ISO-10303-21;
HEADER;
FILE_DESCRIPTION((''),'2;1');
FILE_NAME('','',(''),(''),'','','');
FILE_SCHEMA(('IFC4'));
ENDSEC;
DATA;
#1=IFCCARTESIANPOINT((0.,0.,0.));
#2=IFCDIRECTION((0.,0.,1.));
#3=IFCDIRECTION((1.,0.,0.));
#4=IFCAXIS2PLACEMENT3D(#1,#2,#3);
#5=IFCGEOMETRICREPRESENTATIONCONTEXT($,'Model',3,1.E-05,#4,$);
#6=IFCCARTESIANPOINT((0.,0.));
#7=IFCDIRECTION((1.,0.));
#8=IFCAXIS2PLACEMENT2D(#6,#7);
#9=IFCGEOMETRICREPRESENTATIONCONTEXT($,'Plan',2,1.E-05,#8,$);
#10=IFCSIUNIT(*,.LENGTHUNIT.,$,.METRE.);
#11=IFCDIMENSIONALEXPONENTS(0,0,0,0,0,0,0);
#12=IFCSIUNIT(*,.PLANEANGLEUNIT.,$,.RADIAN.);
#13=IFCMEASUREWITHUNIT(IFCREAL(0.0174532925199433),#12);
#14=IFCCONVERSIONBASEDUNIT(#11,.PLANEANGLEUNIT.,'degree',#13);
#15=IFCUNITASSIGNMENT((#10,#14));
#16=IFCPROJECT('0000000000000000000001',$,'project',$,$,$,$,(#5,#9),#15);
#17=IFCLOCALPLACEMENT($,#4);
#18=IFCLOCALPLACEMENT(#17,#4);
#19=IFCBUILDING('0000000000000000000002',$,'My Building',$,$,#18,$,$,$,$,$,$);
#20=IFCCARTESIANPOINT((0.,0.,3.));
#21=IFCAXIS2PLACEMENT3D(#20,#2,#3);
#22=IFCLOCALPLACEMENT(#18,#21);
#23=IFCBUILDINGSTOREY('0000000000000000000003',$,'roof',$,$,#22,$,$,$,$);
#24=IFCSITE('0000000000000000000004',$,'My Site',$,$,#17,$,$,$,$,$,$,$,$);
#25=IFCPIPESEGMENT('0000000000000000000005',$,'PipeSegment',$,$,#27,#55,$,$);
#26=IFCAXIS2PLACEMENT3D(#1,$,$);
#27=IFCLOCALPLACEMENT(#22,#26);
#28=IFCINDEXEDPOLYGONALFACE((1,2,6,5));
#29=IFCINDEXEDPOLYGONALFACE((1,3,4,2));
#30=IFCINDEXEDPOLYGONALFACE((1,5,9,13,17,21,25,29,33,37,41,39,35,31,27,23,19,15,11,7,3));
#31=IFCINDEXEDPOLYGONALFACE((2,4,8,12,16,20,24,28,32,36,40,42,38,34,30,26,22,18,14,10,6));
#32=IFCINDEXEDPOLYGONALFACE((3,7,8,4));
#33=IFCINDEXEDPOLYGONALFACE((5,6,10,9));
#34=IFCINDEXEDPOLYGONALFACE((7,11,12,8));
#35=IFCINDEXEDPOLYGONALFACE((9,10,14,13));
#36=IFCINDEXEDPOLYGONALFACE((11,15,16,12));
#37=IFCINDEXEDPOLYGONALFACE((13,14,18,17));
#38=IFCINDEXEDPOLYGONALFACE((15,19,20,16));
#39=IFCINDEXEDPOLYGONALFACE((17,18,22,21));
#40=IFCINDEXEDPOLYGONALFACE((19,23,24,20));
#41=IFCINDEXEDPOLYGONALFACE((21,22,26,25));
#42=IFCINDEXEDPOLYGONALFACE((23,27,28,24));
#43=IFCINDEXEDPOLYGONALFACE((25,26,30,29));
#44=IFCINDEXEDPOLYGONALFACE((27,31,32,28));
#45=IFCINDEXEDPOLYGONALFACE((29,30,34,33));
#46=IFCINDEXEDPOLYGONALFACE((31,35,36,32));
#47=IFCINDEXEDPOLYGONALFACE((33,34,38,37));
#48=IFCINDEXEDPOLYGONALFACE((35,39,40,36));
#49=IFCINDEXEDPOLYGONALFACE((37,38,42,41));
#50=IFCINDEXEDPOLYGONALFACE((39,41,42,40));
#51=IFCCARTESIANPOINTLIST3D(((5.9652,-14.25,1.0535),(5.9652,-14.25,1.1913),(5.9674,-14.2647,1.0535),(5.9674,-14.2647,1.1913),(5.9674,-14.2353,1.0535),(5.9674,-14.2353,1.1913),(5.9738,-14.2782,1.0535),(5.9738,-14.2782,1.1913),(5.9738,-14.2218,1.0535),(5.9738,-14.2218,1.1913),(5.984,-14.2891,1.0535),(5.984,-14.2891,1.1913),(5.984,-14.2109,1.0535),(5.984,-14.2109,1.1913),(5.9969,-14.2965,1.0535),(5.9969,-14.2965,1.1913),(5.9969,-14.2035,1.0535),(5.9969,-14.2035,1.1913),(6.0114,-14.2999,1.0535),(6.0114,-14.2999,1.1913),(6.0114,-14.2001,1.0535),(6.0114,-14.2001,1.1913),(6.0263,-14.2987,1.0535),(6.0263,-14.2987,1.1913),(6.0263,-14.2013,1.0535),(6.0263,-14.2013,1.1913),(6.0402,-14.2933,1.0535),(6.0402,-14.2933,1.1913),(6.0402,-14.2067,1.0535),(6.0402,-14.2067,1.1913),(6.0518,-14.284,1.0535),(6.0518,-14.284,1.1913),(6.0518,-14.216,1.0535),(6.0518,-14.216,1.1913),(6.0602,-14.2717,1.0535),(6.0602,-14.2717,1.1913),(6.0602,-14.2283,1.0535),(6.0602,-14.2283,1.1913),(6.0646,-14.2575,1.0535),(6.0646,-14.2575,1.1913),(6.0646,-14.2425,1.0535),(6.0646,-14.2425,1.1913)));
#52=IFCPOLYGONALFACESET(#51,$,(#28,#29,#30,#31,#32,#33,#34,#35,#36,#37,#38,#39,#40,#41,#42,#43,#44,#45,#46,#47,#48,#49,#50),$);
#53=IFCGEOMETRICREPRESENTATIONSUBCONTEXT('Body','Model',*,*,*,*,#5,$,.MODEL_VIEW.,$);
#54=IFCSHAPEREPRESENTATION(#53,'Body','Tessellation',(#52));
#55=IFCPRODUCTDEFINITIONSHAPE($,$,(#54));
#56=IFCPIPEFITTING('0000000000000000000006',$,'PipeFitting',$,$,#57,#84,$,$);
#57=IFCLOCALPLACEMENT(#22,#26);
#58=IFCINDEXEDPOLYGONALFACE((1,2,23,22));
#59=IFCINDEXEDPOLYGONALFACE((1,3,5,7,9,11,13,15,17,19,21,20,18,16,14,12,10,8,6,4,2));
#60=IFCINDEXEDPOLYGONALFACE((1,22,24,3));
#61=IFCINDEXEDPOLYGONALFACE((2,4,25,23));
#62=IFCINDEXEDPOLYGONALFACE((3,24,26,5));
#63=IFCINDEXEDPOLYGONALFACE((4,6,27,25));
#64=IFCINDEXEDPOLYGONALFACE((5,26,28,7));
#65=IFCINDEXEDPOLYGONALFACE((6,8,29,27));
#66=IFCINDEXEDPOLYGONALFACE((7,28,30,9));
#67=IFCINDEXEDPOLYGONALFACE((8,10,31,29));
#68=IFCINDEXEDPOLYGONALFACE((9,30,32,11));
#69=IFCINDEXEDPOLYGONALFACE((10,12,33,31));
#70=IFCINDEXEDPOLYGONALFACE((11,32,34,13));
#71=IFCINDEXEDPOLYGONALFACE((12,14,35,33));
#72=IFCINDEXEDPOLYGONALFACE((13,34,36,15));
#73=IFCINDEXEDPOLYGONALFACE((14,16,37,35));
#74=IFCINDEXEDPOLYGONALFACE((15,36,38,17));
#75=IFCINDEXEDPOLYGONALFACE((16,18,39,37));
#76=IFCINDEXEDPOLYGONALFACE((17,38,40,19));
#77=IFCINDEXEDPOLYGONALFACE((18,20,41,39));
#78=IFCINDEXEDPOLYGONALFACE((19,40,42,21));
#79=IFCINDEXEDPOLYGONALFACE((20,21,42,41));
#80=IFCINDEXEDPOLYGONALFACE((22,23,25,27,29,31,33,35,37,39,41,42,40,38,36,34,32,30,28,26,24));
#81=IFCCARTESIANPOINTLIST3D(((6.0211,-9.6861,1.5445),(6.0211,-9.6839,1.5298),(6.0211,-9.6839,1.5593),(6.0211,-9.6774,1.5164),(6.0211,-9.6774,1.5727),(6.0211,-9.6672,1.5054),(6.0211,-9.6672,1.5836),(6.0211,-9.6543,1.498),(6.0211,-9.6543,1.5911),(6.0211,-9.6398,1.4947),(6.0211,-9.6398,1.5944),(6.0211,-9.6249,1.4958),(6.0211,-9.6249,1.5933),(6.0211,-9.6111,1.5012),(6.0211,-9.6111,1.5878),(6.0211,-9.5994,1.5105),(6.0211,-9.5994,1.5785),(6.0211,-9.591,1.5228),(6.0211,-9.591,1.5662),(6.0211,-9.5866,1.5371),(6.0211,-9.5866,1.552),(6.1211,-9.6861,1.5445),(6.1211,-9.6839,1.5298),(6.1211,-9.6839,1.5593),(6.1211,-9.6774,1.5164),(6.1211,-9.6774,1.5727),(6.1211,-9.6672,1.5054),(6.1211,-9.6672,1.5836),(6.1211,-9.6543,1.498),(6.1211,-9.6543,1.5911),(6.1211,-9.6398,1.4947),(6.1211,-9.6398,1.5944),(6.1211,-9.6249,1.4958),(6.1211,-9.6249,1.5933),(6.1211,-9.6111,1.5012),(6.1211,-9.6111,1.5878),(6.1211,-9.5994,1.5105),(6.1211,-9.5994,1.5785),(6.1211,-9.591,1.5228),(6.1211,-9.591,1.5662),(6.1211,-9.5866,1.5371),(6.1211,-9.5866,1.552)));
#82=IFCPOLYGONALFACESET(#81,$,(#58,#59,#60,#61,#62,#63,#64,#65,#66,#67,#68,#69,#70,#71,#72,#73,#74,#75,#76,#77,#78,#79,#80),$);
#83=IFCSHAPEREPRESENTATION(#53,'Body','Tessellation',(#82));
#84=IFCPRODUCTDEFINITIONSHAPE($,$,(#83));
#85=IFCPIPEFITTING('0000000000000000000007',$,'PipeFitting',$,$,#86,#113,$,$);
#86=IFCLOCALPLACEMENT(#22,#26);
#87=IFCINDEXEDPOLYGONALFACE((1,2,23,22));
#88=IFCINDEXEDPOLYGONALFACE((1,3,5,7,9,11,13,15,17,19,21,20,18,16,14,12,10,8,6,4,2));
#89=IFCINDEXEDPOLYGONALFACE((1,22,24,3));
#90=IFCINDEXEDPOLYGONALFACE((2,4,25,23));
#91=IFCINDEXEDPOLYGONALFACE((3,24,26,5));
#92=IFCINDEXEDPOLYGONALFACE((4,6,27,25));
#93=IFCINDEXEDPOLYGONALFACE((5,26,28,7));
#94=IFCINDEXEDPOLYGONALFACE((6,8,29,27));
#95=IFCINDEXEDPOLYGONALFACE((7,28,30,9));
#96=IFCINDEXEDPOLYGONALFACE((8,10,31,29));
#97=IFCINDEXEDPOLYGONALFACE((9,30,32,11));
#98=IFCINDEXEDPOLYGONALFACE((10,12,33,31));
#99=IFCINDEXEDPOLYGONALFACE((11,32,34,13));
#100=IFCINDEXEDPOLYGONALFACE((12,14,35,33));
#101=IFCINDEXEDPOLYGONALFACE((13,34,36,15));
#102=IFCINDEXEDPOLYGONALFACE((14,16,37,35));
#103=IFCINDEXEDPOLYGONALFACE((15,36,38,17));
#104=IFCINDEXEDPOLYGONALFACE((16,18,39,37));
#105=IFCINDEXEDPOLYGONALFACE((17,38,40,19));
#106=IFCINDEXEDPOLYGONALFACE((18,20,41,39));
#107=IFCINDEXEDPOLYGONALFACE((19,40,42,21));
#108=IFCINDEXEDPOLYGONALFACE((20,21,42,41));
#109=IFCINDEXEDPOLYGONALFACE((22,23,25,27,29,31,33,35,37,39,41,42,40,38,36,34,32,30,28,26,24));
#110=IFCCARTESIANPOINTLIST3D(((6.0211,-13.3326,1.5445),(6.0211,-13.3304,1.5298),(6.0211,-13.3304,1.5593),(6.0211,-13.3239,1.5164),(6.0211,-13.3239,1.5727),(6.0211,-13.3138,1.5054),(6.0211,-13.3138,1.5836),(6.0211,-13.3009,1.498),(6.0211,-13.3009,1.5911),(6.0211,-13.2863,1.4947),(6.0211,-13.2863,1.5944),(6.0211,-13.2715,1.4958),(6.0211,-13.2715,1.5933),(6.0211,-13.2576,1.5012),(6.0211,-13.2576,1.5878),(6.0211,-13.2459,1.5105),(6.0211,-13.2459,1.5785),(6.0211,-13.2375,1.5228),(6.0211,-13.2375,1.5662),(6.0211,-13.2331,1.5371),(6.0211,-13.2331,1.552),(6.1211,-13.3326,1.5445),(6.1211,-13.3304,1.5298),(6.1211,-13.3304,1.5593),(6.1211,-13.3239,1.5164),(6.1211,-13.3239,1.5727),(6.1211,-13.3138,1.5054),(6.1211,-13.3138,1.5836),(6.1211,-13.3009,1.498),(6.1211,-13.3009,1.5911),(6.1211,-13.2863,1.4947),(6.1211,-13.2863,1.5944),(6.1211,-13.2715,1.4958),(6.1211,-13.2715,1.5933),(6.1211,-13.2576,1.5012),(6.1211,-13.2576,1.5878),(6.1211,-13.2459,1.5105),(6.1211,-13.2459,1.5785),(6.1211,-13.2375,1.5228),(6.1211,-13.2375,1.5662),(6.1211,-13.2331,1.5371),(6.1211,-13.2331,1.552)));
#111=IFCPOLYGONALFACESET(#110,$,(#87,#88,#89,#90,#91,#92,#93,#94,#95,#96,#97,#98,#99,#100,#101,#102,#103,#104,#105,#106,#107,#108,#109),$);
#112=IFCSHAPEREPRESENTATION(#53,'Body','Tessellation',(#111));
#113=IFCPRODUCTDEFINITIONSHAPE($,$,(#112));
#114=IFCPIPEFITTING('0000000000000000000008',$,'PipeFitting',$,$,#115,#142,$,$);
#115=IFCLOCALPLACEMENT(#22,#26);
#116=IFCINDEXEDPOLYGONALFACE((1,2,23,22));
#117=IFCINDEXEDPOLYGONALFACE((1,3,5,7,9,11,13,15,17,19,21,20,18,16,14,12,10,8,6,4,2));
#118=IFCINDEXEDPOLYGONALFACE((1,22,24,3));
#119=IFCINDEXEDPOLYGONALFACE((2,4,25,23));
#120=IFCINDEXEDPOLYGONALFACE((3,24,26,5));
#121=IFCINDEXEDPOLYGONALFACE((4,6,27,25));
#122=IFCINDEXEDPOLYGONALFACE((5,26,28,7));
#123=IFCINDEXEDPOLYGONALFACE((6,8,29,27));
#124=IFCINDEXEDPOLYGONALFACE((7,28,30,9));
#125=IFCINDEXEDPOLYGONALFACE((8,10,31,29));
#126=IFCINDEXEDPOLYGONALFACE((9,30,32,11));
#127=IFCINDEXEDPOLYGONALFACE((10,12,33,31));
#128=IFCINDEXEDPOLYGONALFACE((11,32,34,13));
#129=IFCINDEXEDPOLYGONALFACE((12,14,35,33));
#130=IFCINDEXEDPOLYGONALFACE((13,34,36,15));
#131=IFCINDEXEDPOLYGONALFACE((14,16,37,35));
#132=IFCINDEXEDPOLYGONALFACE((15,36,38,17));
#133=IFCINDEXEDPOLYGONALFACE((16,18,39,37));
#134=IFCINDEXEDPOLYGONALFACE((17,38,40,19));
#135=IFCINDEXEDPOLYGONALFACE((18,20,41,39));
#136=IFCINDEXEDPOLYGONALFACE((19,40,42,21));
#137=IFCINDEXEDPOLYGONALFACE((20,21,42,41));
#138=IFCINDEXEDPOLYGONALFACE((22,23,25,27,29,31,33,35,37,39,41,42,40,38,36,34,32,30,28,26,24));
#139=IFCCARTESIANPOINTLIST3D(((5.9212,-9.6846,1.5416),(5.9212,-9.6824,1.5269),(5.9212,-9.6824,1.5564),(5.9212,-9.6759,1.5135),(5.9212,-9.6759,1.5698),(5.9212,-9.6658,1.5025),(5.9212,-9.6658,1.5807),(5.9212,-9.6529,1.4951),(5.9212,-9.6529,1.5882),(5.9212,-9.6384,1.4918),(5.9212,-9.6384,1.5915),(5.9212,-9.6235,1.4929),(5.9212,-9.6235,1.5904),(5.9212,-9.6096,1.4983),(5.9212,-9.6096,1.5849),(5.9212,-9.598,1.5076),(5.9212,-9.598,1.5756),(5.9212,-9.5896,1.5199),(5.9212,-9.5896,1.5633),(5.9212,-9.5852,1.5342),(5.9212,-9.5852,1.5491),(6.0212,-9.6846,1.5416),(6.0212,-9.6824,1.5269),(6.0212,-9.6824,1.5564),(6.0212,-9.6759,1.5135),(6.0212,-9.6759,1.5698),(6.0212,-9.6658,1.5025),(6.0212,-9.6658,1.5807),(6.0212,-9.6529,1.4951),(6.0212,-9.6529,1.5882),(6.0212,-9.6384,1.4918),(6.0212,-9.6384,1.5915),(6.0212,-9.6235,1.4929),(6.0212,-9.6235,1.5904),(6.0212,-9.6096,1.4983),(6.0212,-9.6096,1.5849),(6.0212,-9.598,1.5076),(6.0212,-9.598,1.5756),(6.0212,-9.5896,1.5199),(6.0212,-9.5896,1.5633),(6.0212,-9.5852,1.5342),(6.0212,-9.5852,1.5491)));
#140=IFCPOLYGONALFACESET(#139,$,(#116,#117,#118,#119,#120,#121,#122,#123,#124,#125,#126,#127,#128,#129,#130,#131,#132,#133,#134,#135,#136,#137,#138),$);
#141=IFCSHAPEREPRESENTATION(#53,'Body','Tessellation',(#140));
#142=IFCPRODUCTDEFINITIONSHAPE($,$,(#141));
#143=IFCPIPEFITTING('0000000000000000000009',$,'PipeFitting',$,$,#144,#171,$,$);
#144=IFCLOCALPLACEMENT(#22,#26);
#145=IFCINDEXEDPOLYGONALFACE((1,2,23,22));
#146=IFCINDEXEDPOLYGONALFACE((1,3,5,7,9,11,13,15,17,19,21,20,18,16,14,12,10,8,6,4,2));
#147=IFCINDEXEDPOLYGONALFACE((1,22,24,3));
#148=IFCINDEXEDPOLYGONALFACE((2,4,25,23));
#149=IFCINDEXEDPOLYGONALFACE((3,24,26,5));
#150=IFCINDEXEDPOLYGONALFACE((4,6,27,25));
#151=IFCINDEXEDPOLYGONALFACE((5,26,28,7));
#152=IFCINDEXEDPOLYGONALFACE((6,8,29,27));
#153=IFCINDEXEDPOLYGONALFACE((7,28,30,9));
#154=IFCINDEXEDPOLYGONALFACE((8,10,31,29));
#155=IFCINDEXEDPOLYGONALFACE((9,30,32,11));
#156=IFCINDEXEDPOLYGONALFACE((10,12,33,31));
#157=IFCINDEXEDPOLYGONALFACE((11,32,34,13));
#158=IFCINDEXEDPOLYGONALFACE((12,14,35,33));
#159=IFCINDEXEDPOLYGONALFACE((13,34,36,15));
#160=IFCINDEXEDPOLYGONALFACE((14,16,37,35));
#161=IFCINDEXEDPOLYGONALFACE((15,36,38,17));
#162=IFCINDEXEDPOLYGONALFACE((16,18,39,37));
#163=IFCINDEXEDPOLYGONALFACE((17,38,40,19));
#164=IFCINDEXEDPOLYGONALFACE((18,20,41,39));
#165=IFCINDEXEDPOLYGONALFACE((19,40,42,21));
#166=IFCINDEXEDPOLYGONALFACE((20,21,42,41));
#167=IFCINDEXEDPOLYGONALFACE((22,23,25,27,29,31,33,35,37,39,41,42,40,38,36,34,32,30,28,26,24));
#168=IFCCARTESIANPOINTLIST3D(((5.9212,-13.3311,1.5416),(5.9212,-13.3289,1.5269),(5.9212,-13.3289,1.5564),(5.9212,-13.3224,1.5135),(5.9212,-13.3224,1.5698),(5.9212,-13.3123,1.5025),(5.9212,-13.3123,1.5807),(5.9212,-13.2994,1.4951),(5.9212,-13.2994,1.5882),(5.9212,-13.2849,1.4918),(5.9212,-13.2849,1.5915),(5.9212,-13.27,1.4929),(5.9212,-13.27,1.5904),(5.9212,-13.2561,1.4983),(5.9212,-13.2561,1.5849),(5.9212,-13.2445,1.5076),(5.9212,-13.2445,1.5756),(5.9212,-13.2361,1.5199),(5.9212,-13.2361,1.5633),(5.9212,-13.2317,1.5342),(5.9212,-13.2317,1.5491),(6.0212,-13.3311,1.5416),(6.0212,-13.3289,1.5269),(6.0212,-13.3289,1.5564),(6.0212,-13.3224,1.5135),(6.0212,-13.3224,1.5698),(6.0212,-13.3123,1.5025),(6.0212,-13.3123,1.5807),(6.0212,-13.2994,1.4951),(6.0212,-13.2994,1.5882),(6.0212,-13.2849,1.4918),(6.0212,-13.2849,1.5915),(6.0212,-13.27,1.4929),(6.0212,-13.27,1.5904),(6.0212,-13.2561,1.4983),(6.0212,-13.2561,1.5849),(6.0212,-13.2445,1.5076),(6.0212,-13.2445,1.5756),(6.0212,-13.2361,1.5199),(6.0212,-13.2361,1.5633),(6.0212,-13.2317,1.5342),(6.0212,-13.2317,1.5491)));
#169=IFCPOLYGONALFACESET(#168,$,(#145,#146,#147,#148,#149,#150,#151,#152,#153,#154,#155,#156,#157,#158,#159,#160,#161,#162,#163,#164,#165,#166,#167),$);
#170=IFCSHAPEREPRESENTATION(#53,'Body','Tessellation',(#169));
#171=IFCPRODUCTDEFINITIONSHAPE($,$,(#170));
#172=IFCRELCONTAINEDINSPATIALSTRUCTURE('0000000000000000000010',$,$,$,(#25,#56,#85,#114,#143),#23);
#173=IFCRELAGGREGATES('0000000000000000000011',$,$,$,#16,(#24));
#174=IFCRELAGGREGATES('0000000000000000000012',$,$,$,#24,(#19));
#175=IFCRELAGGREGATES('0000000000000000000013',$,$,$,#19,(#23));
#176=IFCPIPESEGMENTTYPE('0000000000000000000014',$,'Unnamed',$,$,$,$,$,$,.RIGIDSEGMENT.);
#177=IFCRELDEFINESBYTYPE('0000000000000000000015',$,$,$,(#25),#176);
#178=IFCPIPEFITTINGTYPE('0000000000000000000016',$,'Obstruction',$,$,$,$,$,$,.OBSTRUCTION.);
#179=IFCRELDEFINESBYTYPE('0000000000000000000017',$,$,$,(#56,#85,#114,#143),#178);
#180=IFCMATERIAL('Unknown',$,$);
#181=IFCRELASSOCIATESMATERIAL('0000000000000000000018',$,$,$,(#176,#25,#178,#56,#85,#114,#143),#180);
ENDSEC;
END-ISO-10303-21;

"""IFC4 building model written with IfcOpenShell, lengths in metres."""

from ifc_helpers import new_model, entity, si_unit, converted_unit, frame, origin_with_axes, origin_2d_with_axis, place, context, subcontext, project, spatial, circle, extrude, material, material_profile, profile_set, profile_usage, type_object, element, save


model = new_model("IFC4")

# Units and contexts
model_context = context("Model", 3, precision=1e-05, world=origin_with_axes())
plan_context = context("Plan", 2, precision=1e-05, world=origin_2d_with_axis())
body_context_1 = subcontext(model_context, "Body", "Model", "MODEL_VIEW")
ifc_project = project(units=[si_unit("LENGTHUNIT", "METRE"), converted_unit("PLANEANGLEUNIT", "degree", entity("IfcReal", 0.0174532925199433), si_unit("PLANEANGLEUNIT", "RADIAN"), dimensions=[0, 0, 0, 0, 0, 0, 0])], contexts=[model_context, plan_context])

# Site, building, storey
site_placement = place(None, origin_with_axes())
site = spatial("IfcSite", under=ifc_project, at=site_placement, Name="My Site")
building_placement = place(site_placement, origin_with_axes())
building = spatial("IfcBuilding", under=site, at=building_placement, Name="My Building")
storey_placement = place(building_placement, frame((0.0, 0.0, 3.0), z_axis=(0.0, 0.0, 1.0), x_axis=(1.0, 0.0, 0.0)))
storey = spatial("IfcBuildingStorey", under=building, at=storey_placement, Name="roof")

# Shared definitions
ifc_material = material(Name="Unknown")

# Pipe segment
ifc_material_profile_1 = material_profile(ifc_material, circle(Radius=0.05))
ifc_profile_set_1 = profile_set([ifc_material_profile_1])
pipe_segment_type = type_object("IfcPipeSegmentType", Name="Unnamed", PredefinedType="RIGIDSEGMENT", material=ifc_profile_set_1)
ifc_profile_usage_1 = profile_usage(ifc_profile_set_1, cardinal=5)
pipe_segment_1_placement = place(storey_placement, frame((6.0152, -14.25, 1.0535), z_axis=(-0.000001, -0.000001, 1.0), x_axis=(-1.0, 0.0, -0.000001)))
element("IfcPipeSegment", 1, at=pipe_segment_1_placement, inside=storey, type_object=pipe_segment_type, material=ifc_profile_usage_1, Name="PipeSegment", context=body_context_1, shape_type="SweptSolid", body=[
    extrude(circle(Radius=0.05), origin_with_axes(), (0.0, 0.0, 1.0), 0.1377),
])

# Pipe fittings
ifc_material_profile_2 = material_profile(ifc_material, circle(Radius=0.05))
ifc_profile_set_2 = profile_set([ifc_material_profile_2])
ifc_profile_usage_2 = profile_usage(ifc_profile_set_2, cardinal=5)
pipe_fitting_type_1 = type_object("IfcPipeFittingType", Name="Obstruction", PredefinedType="OBSTRUCTION", material=ifc_profile_set_2)
pipe_fitting_1_placement = place(storey_placement, frame((6.0211, -9.6361, 1.5445), z_axis=(1.0, 0.0, 0.0), x_axis=(0.0, -1.0, 0.0)))
element("IfcPipeFitting", 2, at=pipe_fitting_1_placement, inside=storey, type_object=pipe_fitting_type_1, material=ifc_profile_usage_2, Name="PipeFitting", context=body_context_1, shape_type="SweptSolid", body=[
    extrude(circle(Radius=0.05), origin_with_axes(), (0.0, 0.0, 1.0), 0.1),
])
ifc_profile_usage_3 = profile_usage(ifc_profile_set_2, cardinal=5)
pipe_fitting_2_placement = place(storey_placement, frame((6.0211, -13.2826, 1.5445), z_axis=(1.0, 0.0, 0.0), x_axis=(0.0, -1.0, 0.0)))
element("IfcPipeFitting", 3, at=pipe_fitting_2_placement, inside=storey, type_object=pipe_fitting_type_1, material=ifc_profile_usage_3, Name="PipeFitting", context=body_context_1, shape_type="SweptSolid", body=[
    extrude(circle(Radius=0.05), origin_with_axes(), (0.0, 0.0, 1.0), 0.1),
])
ifc_profile_usage_4 = profile_usage(ifc_profile_set_2, cardinal=5)
pipe_fitting_3_placement = place(storey_placement, frame((6.0212, -9.6346, 1.5416), z_axis=(-1.0, 0.0, 0.0), x_axis=(0.0, -1.0, 0.0)))
element("IfcPipeFitting", 4, at=pipe_fitting_3_placement, inside=storey, type_object=pipe_fitting_type_1, material=ifc_profile_usage_4, Name="PipeFitting", context=body_context_1, shape_type="SweptSolid", body=[
    extrude(circle(Radius=0.05), origin_with_axes(), (0.0, 0.0, 1.0), 0.1),
])
ifc_profile_usage_5 = profile_usage(ifc_profile_set_2, cardinal=5)
pipe_fitting_4_placement = place(storey_placement, frame((6.0212, -13.2811, 1.5416), z_axis=(-1.0, 0.0, 0.0), x_axis=(0.0, -1.0, 0.0)))
element("IfcPipeFitting", 5, at=pipe_fitting_4_placement, inside=storey, type_object=pipe_fitting_type_1, material=ifc_profile_usage_5, Name="PipeFitting", context=body_context_1, shape_type="SweptSolid", body=[
    extrude(circle(Radius=0.05), origin_with_axes(), (0.0, 0.0, 1.0), 0.1),
])

save(model, "model.ifc")
